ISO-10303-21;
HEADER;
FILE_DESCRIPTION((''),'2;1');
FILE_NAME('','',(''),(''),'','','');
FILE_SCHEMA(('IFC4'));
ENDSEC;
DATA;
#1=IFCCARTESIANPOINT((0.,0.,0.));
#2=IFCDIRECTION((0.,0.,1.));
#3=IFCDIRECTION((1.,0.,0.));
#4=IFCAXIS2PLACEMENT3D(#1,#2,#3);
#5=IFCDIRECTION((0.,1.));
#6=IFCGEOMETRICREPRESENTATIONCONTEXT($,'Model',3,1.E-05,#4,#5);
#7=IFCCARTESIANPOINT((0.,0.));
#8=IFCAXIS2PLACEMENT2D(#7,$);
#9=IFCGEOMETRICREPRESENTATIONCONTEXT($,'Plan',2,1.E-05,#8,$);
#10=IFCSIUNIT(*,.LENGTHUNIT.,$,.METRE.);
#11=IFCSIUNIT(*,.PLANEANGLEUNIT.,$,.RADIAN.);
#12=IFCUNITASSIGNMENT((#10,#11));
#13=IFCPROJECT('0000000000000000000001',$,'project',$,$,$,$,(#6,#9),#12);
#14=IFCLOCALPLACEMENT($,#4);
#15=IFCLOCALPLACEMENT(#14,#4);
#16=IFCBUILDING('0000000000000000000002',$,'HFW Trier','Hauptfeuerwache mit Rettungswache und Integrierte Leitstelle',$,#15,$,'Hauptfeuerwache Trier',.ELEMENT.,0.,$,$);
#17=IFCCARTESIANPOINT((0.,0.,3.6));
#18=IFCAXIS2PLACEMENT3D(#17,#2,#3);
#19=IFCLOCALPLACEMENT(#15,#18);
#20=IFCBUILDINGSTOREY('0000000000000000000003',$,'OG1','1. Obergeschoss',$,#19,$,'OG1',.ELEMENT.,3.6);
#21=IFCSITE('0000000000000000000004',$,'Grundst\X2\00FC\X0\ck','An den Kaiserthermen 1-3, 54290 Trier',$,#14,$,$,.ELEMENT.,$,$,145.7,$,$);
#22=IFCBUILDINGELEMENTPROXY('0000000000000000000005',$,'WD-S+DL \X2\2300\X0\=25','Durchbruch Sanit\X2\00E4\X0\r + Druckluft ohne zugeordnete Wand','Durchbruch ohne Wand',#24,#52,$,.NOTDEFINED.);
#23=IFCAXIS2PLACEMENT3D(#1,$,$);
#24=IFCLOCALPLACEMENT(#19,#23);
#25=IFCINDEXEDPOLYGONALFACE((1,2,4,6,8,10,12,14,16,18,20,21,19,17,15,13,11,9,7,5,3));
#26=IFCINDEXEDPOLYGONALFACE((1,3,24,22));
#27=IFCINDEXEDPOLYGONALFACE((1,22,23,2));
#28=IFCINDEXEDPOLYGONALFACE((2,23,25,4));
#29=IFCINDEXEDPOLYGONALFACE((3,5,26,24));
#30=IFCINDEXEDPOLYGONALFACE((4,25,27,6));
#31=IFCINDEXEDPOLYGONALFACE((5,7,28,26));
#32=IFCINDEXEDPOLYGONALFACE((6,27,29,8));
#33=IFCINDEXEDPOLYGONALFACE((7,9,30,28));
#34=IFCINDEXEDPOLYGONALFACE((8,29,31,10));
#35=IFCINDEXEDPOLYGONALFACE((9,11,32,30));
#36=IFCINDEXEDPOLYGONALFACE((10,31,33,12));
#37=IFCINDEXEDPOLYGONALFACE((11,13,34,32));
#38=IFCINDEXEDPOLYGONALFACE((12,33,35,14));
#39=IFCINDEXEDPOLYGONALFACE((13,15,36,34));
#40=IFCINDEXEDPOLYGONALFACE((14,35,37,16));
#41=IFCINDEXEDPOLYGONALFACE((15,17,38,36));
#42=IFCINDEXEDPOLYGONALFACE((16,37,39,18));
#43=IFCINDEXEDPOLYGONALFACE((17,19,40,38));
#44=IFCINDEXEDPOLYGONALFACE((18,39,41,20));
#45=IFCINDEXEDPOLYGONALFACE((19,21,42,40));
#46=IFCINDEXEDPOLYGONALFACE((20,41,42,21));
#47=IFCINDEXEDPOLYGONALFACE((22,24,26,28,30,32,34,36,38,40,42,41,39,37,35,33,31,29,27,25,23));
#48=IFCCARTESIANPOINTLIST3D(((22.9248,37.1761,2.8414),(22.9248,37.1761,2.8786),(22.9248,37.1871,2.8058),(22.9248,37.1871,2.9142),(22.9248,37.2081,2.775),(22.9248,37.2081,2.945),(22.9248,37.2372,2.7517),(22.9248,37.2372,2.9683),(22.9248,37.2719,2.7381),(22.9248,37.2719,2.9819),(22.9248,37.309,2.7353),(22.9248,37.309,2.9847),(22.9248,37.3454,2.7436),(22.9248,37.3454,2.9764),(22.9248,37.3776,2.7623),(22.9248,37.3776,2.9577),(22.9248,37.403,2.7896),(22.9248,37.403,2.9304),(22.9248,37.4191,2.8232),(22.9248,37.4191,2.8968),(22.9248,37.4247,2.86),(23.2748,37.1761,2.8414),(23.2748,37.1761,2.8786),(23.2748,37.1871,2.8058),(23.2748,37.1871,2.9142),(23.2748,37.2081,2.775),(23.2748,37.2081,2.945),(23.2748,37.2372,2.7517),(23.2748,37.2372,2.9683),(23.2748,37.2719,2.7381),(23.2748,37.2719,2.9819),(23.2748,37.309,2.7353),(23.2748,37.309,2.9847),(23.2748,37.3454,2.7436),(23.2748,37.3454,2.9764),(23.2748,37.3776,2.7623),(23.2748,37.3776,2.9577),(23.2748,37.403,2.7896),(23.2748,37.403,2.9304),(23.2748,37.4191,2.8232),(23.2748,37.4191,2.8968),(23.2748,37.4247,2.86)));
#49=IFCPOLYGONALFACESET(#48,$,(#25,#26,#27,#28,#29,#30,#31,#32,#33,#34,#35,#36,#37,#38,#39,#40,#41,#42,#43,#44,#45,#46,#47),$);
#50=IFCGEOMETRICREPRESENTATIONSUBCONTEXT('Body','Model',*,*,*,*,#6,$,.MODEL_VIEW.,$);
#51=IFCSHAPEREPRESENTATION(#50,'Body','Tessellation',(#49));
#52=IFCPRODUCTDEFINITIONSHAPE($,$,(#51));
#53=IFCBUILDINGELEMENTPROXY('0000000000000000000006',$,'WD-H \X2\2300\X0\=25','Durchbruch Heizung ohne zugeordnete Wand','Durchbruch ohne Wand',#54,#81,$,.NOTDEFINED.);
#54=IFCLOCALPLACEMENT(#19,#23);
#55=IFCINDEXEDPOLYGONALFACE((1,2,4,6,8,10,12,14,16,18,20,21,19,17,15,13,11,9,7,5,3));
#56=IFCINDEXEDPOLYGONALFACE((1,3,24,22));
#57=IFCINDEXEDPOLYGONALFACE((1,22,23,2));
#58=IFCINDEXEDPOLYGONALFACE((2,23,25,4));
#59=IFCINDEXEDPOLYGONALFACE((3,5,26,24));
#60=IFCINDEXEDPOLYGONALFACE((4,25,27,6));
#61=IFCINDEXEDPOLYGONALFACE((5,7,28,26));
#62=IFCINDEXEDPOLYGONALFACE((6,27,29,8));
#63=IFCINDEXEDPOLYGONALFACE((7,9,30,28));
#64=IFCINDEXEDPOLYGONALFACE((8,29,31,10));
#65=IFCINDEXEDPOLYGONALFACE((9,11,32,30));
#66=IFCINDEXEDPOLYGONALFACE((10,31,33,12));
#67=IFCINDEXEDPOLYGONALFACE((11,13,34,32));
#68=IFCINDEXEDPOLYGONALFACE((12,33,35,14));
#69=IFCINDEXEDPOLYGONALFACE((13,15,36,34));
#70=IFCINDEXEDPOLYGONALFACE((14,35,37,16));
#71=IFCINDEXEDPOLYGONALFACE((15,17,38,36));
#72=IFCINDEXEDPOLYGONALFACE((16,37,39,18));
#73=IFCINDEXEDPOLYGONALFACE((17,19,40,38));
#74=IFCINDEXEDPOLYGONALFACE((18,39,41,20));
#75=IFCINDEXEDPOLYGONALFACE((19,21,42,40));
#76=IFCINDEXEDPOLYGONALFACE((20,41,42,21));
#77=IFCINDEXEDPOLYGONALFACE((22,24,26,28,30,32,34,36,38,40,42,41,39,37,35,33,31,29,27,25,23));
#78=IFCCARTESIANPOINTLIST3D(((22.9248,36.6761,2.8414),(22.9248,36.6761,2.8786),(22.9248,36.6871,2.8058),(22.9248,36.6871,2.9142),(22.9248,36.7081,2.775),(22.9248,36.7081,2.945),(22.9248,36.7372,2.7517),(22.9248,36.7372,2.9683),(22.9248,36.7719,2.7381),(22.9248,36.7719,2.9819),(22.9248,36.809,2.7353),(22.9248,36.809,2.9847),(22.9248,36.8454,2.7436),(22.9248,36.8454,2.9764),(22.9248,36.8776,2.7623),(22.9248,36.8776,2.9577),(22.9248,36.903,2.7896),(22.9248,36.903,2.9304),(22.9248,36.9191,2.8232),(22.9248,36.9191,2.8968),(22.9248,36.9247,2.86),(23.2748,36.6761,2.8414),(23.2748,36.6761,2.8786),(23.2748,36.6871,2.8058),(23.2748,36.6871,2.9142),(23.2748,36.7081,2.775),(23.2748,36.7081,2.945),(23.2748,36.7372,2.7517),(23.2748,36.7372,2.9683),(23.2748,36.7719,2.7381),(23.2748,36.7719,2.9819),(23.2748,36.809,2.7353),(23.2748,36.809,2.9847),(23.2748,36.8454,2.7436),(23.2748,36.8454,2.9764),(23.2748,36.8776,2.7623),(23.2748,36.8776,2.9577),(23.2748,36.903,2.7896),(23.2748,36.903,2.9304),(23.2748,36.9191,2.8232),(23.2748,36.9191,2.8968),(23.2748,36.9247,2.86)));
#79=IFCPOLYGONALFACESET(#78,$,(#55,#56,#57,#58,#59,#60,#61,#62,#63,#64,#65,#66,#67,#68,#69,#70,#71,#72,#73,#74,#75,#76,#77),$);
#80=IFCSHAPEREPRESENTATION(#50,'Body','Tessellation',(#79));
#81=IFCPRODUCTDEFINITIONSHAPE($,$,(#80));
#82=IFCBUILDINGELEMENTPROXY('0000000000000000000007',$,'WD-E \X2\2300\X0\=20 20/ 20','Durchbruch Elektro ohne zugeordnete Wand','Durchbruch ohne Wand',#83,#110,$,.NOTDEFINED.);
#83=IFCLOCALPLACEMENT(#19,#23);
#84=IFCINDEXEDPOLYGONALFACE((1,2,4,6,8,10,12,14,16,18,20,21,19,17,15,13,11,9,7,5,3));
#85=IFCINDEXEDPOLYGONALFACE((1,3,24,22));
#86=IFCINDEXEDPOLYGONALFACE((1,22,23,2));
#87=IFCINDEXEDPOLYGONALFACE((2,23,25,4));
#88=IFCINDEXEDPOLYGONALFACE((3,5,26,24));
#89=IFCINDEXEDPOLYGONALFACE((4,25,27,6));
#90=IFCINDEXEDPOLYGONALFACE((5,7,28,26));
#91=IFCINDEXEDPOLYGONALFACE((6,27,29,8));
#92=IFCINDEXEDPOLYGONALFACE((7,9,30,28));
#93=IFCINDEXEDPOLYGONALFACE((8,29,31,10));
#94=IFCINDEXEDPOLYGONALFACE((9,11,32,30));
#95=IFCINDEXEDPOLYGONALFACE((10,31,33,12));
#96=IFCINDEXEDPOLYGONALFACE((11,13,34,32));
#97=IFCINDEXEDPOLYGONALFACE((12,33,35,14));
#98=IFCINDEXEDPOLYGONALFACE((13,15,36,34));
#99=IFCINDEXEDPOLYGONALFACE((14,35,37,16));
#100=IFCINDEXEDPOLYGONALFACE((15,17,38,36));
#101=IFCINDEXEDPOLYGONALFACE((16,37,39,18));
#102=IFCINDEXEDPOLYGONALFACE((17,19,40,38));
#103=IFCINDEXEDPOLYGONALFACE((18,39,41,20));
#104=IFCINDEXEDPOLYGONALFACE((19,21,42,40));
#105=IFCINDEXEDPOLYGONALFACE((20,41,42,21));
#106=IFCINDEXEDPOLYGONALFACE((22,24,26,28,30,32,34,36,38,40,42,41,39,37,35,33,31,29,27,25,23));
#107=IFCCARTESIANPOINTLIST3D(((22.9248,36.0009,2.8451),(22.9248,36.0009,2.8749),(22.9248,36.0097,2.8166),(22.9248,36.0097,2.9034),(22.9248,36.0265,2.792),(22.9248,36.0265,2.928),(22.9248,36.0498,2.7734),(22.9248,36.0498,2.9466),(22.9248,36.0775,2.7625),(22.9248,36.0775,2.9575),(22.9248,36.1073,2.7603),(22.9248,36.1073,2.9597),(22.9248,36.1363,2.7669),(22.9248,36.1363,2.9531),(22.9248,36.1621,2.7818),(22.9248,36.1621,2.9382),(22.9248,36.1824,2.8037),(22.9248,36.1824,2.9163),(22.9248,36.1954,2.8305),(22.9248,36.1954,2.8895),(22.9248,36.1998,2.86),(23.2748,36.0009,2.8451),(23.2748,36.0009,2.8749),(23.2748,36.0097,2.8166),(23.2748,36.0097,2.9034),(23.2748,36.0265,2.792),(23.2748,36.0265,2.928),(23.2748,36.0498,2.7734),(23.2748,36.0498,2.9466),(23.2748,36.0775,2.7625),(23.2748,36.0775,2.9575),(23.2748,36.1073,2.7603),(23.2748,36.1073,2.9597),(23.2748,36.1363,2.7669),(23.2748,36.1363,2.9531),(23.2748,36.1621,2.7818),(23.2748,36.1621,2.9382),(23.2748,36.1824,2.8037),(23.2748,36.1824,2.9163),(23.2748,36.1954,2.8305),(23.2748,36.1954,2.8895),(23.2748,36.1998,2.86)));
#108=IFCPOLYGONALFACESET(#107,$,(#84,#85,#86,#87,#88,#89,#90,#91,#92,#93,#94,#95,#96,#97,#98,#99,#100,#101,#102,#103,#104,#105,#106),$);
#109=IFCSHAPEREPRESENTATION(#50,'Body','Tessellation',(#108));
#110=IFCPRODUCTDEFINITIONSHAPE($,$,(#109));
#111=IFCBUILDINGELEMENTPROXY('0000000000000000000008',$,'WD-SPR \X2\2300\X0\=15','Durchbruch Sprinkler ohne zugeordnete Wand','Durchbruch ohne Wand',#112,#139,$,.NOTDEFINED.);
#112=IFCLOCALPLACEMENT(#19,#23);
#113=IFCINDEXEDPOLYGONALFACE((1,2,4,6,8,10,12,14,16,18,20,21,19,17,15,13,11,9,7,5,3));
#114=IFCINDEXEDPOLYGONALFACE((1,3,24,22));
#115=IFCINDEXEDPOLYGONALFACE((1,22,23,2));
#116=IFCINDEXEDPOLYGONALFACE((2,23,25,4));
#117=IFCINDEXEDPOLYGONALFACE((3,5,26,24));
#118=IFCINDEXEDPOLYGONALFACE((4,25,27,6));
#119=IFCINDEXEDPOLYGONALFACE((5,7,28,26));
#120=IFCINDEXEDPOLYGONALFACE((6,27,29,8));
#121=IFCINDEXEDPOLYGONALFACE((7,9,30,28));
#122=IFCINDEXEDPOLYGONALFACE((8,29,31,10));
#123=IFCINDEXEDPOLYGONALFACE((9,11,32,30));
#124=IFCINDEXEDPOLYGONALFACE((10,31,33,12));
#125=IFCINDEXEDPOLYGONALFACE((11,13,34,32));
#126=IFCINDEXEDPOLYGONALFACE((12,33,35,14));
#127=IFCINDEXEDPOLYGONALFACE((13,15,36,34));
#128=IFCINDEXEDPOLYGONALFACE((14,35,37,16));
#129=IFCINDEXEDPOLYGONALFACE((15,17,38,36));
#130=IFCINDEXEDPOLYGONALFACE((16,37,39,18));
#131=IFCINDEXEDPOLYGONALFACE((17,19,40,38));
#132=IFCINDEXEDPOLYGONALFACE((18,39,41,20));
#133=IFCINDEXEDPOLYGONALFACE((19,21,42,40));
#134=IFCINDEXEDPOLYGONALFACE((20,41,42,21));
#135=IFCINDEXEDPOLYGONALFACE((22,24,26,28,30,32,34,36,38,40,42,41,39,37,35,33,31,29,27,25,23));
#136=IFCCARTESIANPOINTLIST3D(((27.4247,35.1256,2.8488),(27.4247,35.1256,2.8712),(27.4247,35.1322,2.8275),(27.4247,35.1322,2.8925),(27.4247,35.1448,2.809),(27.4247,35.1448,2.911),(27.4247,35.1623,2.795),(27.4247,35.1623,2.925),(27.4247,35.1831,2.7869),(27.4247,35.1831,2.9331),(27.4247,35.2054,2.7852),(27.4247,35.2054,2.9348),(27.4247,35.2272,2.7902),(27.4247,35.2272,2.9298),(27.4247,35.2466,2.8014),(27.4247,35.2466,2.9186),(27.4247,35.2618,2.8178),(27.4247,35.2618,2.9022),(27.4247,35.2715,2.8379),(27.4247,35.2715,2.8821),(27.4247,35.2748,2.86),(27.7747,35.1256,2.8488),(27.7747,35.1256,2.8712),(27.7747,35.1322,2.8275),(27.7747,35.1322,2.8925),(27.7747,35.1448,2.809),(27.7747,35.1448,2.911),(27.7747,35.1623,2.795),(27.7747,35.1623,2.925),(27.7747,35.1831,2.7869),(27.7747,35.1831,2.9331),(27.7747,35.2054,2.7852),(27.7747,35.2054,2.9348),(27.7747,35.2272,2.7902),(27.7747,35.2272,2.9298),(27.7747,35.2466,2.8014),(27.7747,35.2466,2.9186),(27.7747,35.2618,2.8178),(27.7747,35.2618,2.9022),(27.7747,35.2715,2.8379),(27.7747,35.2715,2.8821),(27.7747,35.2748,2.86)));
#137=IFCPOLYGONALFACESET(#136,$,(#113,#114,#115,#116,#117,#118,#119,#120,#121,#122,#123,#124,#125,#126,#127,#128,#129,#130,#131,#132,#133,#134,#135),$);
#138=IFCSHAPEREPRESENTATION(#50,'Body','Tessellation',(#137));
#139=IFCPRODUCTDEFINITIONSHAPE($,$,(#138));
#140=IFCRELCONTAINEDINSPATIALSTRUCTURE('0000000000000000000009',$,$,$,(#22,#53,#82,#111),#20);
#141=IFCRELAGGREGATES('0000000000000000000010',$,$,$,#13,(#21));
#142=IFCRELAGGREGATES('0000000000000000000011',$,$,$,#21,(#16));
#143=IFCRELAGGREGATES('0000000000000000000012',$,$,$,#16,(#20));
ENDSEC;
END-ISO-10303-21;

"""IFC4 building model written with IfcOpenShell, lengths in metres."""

from ifc_helpers import new_model, si_unit, direction, frame, origin_with_axes, origin_2d, place, context, subcontext, project, spatial, circle, extrude, element, save


model = new_model("IFC4")

# Units and contexts
model_context = context("Model", 3, precision=1e-05, world=origin_with_axes(), true_north=direction((0.0, 1.0)))
plan_context = context("Plan", 2, precision=1e-05, world=origin_2d())
body_context = subcontext(model_context, "Body", "Model", "MODEL_VIEW")
ifc_project = project(units=[si_unit("LENGTHUNIT", "METRE"), si_unit("PLANEANGLEUNIT", "RADIAN")], contexts=[model_context, plan_context])

# Site, building, storey
site_placement = place(None, origin_with_axes())
site = spatial("IfcSite", under=ifc_project, at=site_placement, Name="Grundstück", Description="An den Kaiserthermen 1-3, 54290 Trier", CompositionType="ELEMENT", RefElevation=145.7)
building_placement = place(site_placement, origin_with_axes())
building = spatial("IfcBuilding", under=site, at=building_placement, Name="HFW Trier", Description="Hauptfeuerwache mit Rettungswache und Integrierte Leitstelle", LongName="Hauptfeuerwache Trier", CompositionType="ELEMENT", ElevationOfRefHeight=0.0)
storey_placement = place(building_placement, frame((0.0, 0.0, 3.6), z_axis=(0.0, 0.0, 1.0), x_axis=(1.0, 0.0, 0.0)))
storey = spatial("IfcBuildingStorey", under=building, at=storey_placement, Name="OG1", Description="1. Obergeschoss", LongName="OG1", CompositionType="ELEMENT", Elevation=3.6)

# Building element proxies
for number, where, z_axis, x_axis, name, description in (
    (1, (23.0998, 37.2997, 2.735), (0.0, 0.0, 1.0), (0.0, 1.0, 0.0), "WD-S+DL ⌀=25", "Durchbruch Sanitär + Druckluft ohne zugeordnete Wand"),
    (2, (23.0998, 36.7997, 2.735), (0.0, 0.0, 1.0), (0.0, 1.0, 0.0), "WD-H ⌀=25", "Durchbruch Heizung ohne zugeordnete Wand"),
):
    element("IfcBuildingElementProxy", number, at=place(storey_placement, frame(where, z_axis=z_axis, x_axis=x_axis)), inside=storey, Name=name, Description=description, ObjectType="Durchbruch ohne Wand", PredefinedType="NOTDEFINED", context=body_context, shape_type="SweptSolid", body=[
        extrude(circle(Radius=0.125, at=origin_2d()), frame((0.0, -0.175, 0.125), z_axis=(0.0, 1.0, 0.0), x_axis=(1.0, 0.0, 0.0)), (0.0, 0.0, 1.0), 0.35),
    ])
proxy_1_placement = place(storey_placement, frame((23.0998, 36.0998, 2.76), z_axis=(0.0, 0.0, 1.0), x_axis=(0.0, 1.0, 0.0)))
element("IfcBuildingElementProxy", 3, at=proxy_1_placement, inside=storey, Name="WD-E ⌀=20 20/ 20", Description="Durchbruch Elektro ohne zugeordnete Wand", ObjectType="Durchbruch ohne Wand", PredefinedType="NOTDEFINED", context=body_context, shape_type="SweptSolid", body=[
    extrude(circle(Radius=0.1, at=origin_2d()), frame((0.0, -0.175, 0.1), z_axis=(0.0, 1.0, 0.0), x_axis=(1.0, 0.0, 0.0)), (0.0, 0.0, 1.0), 0.35),
])
proxy_2_placement = place(storey_placement, frame((27.5997, 35.1998, 2.785), z_axis=(0.0, 0.0, 1.0), x_axis=(0.0, 1.0, 0.0)))
element("IfcBuildingElementProxy", 4, at=proxy_2_placement, inside=storey, Name="WD-SPR ⌀=15", Description="Durchbruch Sprinkler ohne zugeordnete Wand", ObjectType="Durchbruch ohne Wand", PredefinedType="NOTDEFINED", context=body_context, shape_type="SweptSolid", body=[
    extrude(circle(Radius=0.075, at=origin_2d()), frame((0.0, -0.175, 0.075), z_axis=(0.0, 1.0, 0.0), x_axis=(1.0, 0.0, 0.0)), (0.0, 0.0, 1.0), 0.35),
])

save(model, "model.ifc")
